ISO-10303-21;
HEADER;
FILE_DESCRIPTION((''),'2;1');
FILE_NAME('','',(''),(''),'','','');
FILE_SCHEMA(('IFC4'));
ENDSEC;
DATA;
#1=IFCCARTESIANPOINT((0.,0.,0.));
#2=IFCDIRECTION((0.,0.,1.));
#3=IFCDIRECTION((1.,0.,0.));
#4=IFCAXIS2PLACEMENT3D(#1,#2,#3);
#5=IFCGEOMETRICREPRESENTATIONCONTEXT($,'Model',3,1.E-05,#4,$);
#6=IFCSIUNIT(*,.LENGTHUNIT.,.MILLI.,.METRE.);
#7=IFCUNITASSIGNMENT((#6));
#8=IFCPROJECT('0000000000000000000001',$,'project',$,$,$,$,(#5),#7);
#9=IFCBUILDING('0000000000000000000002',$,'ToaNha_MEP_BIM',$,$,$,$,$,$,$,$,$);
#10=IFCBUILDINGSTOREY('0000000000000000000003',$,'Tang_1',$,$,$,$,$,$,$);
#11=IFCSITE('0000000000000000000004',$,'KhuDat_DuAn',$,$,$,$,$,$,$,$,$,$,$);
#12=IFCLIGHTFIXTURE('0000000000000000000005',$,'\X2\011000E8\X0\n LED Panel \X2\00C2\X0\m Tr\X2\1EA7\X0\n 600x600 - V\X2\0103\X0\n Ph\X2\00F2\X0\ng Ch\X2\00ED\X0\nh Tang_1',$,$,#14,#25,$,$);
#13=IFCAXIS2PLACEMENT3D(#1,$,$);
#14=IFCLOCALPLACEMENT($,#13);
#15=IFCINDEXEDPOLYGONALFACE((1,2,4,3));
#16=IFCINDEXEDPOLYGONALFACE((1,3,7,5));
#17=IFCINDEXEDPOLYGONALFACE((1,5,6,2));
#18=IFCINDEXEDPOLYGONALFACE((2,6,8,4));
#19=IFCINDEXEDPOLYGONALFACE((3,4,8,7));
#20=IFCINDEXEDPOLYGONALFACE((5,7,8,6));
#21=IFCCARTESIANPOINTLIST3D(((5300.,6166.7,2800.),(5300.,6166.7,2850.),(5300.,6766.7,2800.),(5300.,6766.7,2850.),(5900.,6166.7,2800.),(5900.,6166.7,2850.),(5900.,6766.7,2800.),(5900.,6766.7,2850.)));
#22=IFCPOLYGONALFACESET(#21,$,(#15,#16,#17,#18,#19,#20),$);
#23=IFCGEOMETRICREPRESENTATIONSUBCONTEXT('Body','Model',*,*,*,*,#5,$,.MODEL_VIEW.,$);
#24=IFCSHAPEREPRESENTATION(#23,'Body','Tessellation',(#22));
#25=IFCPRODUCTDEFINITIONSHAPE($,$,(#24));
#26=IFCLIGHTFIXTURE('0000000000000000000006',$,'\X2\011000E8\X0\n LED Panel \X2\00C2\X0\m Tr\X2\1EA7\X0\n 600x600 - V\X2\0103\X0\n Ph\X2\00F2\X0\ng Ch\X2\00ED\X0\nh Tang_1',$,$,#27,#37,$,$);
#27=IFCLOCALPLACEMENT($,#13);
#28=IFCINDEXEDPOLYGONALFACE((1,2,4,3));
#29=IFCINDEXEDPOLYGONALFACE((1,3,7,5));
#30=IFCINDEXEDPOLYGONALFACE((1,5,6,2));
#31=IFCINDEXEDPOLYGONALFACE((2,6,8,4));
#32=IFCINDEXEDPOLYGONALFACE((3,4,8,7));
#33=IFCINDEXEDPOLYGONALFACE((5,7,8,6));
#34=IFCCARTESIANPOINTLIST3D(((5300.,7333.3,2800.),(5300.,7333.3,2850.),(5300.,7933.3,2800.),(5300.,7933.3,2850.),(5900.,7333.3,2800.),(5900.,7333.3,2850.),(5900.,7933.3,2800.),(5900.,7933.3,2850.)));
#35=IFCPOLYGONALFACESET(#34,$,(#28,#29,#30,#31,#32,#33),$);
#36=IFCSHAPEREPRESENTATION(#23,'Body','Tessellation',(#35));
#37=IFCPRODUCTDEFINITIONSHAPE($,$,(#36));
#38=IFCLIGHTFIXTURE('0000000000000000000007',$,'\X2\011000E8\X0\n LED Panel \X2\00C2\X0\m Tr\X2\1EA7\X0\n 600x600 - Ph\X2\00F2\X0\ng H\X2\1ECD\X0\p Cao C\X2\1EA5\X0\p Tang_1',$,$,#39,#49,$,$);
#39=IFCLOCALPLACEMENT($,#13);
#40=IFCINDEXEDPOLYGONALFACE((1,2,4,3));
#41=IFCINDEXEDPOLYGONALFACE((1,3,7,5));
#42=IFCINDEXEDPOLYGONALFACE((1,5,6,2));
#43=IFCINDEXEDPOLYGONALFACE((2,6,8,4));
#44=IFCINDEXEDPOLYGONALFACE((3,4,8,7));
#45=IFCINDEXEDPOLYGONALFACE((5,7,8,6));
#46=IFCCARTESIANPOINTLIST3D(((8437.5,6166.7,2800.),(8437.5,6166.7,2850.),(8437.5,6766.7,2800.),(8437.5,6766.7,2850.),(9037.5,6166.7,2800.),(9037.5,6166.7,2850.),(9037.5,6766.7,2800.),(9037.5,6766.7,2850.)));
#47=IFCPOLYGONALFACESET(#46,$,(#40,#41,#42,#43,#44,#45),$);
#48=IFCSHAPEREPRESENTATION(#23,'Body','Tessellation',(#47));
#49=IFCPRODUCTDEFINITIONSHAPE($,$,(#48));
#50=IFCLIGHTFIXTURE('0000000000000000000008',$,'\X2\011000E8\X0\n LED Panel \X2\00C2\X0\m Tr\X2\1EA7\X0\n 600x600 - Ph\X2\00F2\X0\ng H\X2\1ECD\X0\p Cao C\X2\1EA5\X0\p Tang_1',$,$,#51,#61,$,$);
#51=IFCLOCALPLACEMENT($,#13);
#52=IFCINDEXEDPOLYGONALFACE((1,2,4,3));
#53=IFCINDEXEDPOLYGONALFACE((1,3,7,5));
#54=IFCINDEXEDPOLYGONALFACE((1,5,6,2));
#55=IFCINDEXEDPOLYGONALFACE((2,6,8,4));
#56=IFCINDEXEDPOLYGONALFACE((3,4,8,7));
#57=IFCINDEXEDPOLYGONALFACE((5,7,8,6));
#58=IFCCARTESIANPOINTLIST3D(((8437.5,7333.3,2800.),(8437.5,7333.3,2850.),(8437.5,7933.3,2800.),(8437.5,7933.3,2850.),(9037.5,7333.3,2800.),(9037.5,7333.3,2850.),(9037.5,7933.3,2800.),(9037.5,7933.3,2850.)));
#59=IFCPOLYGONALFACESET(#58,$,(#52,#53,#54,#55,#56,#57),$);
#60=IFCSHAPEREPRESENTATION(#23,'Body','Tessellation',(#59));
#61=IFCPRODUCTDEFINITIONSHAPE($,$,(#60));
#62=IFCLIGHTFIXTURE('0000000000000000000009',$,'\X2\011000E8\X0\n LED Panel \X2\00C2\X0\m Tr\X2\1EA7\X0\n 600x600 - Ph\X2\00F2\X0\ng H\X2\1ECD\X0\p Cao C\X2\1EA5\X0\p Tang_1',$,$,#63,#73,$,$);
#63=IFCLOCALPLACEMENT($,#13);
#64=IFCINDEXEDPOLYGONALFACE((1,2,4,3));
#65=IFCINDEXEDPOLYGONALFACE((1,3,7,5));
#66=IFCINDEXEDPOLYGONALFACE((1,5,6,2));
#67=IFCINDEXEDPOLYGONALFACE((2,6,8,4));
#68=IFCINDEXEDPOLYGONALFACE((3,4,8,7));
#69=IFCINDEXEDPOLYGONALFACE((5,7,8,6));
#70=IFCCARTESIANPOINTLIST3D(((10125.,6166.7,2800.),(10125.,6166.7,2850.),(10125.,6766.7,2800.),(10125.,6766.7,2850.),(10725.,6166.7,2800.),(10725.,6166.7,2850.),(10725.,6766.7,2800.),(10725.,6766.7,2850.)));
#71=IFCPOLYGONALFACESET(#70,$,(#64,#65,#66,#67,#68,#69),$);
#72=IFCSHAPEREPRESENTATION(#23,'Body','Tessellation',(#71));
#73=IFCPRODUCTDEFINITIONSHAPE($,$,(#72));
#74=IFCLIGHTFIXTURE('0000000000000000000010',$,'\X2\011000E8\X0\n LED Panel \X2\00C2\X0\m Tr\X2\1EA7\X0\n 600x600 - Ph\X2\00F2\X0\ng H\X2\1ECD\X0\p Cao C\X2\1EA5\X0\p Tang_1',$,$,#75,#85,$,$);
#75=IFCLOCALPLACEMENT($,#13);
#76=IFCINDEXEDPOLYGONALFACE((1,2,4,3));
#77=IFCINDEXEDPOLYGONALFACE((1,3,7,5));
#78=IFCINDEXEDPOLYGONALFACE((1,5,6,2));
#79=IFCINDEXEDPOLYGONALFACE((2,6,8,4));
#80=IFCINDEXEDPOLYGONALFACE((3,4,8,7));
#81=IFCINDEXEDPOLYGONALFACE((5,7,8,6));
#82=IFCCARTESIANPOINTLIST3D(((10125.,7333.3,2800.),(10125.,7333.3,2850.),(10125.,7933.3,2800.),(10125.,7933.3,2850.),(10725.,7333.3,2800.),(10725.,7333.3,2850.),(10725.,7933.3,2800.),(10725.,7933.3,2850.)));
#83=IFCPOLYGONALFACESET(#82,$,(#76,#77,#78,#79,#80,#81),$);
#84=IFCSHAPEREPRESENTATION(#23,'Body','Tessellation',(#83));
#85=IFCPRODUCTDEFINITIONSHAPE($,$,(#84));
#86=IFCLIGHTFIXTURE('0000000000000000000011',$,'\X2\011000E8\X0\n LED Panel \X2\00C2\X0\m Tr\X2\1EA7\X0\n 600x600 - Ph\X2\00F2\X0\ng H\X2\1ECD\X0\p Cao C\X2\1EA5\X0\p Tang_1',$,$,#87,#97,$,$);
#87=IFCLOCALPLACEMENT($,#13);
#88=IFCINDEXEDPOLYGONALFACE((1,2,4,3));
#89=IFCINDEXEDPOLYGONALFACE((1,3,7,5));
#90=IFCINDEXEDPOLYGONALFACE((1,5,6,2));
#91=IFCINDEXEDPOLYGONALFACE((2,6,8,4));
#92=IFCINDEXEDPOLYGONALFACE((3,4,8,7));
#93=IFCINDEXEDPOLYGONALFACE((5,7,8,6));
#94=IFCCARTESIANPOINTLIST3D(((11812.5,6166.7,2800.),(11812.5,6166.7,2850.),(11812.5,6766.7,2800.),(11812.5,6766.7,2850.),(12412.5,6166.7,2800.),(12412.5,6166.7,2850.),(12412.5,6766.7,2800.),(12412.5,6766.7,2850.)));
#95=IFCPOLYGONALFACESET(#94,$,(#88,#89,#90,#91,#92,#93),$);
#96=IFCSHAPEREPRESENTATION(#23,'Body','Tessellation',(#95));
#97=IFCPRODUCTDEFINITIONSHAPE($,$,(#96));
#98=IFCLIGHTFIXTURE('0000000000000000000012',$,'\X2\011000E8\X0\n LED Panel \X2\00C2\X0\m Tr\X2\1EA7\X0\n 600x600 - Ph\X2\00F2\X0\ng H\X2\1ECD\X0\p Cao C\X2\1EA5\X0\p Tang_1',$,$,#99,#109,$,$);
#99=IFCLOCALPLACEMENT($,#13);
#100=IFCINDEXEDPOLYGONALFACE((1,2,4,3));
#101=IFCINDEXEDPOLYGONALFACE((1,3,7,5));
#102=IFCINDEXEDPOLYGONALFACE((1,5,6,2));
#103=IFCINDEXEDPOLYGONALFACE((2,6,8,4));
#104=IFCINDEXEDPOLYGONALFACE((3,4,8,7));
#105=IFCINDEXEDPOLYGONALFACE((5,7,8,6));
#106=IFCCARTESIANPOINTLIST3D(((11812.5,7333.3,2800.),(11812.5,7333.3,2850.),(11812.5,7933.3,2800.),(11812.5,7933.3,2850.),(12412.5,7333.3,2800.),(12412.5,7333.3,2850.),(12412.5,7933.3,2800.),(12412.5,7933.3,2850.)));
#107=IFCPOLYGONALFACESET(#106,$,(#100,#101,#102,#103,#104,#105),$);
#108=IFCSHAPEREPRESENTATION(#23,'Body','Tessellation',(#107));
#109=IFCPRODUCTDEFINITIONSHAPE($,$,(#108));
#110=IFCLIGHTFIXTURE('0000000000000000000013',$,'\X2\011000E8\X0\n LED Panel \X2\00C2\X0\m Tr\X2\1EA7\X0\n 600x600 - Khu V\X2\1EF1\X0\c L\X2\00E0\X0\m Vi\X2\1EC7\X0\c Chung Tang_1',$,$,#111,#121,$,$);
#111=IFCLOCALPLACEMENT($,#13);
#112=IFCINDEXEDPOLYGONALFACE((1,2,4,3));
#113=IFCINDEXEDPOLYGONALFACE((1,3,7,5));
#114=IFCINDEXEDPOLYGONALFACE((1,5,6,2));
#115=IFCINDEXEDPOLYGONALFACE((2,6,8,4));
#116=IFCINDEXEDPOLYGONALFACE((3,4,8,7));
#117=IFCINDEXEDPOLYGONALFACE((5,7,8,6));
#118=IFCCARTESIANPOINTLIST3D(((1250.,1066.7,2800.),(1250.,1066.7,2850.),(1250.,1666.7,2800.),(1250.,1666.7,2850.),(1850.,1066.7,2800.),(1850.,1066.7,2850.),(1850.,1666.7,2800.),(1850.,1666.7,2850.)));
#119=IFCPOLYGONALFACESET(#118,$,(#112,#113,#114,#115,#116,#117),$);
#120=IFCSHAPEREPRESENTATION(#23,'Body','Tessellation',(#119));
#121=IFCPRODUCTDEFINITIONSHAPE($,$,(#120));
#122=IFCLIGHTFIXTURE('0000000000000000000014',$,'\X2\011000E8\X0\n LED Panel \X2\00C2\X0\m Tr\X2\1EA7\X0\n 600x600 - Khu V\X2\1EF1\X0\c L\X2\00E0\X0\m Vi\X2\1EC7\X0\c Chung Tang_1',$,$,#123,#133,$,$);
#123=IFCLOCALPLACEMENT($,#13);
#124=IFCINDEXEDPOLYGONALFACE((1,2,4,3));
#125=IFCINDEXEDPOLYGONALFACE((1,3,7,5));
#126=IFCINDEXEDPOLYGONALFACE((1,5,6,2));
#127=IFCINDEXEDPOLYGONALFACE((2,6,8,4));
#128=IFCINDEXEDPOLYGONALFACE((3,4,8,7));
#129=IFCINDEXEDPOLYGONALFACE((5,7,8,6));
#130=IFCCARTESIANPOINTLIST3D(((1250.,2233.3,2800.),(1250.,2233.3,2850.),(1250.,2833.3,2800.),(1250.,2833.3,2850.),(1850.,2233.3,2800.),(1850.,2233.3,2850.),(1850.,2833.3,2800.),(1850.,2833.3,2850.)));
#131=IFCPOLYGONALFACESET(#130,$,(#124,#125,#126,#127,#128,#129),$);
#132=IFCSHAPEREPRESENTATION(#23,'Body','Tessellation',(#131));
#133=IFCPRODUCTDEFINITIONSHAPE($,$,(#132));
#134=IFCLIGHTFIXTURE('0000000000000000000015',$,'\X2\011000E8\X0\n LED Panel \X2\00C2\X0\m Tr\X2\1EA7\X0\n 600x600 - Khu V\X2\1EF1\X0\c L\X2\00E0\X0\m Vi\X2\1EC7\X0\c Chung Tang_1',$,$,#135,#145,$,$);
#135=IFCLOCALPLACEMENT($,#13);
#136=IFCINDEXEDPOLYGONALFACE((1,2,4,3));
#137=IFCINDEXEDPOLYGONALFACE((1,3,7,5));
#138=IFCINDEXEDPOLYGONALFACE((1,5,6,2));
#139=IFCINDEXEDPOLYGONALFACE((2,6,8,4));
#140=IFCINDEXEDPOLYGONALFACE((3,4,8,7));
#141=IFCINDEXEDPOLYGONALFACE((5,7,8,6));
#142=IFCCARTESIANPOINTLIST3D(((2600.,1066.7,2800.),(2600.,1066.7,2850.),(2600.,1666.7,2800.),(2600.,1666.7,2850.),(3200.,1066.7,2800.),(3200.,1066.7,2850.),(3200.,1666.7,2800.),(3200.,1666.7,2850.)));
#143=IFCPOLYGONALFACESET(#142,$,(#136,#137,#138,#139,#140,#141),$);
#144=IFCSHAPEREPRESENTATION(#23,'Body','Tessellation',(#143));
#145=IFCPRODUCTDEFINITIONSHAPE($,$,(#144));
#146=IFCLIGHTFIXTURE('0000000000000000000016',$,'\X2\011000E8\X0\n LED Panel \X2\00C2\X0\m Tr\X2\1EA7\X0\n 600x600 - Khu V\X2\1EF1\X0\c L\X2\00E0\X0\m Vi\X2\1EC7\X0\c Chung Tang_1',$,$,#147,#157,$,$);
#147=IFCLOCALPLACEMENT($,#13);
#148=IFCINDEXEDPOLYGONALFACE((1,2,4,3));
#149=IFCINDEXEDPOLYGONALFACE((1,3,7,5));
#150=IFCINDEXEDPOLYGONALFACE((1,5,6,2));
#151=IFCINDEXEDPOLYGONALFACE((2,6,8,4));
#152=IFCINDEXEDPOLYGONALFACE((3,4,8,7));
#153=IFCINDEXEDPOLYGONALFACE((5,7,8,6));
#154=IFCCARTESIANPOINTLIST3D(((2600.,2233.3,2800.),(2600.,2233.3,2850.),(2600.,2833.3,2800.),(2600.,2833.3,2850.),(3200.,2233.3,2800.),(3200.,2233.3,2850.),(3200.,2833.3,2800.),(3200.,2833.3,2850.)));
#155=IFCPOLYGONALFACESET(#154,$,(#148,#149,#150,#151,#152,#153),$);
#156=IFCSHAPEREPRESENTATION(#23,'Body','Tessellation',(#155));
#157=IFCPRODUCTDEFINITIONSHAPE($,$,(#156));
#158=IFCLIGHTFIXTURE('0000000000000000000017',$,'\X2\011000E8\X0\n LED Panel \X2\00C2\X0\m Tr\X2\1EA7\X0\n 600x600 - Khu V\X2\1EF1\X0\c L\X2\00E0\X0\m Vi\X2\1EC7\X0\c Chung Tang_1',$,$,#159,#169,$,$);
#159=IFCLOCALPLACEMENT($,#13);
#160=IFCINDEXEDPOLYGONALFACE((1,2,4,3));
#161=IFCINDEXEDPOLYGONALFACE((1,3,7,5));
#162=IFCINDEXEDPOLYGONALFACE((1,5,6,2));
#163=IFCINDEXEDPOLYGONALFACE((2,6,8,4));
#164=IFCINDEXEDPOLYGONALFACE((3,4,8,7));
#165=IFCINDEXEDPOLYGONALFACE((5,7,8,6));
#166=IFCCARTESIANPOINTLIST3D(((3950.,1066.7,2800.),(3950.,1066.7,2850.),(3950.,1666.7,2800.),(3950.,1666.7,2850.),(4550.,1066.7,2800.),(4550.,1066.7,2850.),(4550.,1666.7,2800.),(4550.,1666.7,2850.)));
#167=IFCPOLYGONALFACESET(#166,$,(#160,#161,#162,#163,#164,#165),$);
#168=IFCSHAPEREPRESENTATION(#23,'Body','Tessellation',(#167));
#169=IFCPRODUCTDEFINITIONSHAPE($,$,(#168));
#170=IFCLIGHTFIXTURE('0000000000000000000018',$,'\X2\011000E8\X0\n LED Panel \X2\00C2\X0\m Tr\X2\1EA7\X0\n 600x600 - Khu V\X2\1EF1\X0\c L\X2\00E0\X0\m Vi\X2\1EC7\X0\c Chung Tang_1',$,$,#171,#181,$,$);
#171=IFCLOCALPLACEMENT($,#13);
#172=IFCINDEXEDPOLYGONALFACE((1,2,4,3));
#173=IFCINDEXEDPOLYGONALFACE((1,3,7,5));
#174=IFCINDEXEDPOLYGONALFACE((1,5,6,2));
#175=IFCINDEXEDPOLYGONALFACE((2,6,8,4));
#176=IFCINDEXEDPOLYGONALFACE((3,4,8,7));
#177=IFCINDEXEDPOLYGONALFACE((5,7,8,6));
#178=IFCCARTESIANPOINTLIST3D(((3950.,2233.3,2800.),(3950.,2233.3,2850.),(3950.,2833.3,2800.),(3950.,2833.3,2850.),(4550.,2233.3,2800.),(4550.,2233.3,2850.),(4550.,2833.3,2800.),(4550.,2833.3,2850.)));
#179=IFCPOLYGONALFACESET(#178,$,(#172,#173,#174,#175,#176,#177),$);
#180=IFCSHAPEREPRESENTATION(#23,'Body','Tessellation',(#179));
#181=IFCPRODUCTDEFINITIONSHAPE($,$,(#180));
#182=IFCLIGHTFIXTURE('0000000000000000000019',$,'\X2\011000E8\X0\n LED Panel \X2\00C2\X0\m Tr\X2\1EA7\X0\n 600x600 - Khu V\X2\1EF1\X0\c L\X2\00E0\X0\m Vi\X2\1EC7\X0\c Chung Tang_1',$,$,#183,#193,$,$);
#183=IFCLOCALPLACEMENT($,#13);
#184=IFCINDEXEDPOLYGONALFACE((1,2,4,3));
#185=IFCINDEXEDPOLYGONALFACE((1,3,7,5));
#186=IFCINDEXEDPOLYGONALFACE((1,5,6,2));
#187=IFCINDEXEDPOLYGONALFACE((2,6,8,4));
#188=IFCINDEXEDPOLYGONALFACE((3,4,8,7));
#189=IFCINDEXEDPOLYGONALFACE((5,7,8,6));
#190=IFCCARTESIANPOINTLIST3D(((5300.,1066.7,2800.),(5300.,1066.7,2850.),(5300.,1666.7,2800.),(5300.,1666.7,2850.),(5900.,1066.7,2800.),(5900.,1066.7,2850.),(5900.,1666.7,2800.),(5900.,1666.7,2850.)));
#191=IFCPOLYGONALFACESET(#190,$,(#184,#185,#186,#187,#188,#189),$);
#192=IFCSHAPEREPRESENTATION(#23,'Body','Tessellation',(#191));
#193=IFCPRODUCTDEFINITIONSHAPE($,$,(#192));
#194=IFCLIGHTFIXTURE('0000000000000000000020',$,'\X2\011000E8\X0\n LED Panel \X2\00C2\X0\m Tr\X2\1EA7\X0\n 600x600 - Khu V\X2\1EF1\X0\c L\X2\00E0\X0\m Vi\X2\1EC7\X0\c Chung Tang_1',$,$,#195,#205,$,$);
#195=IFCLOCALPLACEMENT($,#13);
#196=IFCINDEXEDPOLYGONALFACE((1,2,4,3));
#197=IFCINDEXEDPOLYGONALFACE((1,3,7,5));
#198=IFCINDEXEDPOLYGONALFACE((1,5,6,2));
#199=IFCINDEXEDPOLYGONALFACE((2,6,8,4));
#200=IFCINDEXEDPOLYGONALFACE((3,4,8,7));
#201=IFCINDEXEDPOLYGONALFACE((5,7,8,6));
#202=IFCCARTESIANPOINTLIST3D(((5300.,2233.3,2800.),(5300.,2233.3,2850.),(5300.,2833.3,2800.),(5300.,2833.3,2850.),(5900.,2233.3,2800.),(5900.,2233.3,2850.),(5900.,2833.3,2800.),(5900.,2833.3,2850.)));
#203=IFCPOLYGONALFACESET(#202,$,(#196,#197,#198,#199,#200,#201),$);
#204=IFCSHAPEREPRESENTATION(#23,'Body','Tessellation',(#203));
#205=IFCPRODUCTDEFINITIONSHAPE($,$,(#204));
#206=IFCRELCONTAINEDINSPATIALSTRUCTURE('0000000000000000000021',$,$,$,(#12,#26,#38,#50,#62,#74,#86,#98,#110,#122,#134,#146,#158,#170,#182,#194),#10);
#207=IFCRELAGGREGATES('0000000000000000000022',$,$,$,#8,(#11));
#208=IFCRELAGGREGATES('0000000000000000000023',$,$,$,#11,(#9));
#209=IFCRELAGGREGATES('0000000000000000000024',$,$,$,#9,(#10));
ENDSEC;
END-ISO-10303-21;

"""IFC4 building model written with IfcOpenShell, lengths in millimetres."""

from ifc_helpers import new_model, si_unit, frame, origin_with_axes, context, subcontext, project, spatial, polyline, outline, extrude, element, save


model = new_model("IFC4")

# Units and contexts
model_context = context("Model", 3, precision=1e-05, world=origin_with_axes())
body_context = subcontext(model_context, "Body", "Model", "MODEL_VIEW")
ifc_project = project(units=[si_unit("LENGTHUNIT", "METRE", prefix="MILLI")], contexts=[model_context])

# Site, building, storey
site = spatial("IfcSite", under=ifc_project, Name="KhuDat_DuAn")
building = spatial("IfcBuilding", under=site, Name="ToaNha_MEP_BIM")
storey = spatial("IfcBuildingStorey", under=building, Name="Tang_1")

# Light fixtures
element("IfcLightFixture", 1, inside=storey, Name="Đèn LED Panel Âm Trần 600x600 - Văn Phòng Chính Tang_1", context=body_context, shape_type="SweptSolid", body=[
    extrude(outline(polyline([(5300.0, 6166.7), (5900.0, 6166.7), (5900.0, 6766.7), (5300.0, 6766.7), (5300.0, 6166.7)])), frame((0.0, 0.0, 2800.0), z_axis=(0.0, 0.0, 1.0), x_axis=(1.0, 0.0, 0.0)), (0.0, 0.0, 1.0), 50.0),
])
element("IfcLightFixture", 2, inside=storey, Name="Đèn LED Panel Âm Trần 600x600 - Văn Phòng Chính Tang_1", context=body_context, shape_type="SweptSolid", body=[
    extrude(outline(polyline([(5300.0, 7333.3), (5900.0, 7333.3), (5900.0, 7933.3), (5300.0, 7933.3), (5300.0, 7333.3)])), frame((0.0, 0.0, 2800.0), z_axis=(0.0, 0.0, 1.0), x_axis=(1.0, 0.0, 0.0)), (0.0, 0.0, 1.0), 50.0),
])
element("IfcLightFixture", 3, inside=storey, Name="Đèn LED Panel Âm Trần 600x600 - Phòng Họp Cao Cấp Tang_1", context=body_context, shape_type="SweptSolid", body=[
    extrude(outline(polyline([(8437.5, 6166.7), (9037.5, 6166.7), (9037.5, 6766.7), (8437.5, 6766.7), (8437.5, 6166.7)])), frame((0.0, 0.0, 2800.0), z_axis=(0.0, 0.0, 1.0), x_axis=(1.0, 0.0, 0.0)), (0.0, 0.0, 1.0), 50.0),
])
element("IfcLightFixture", 4, inside=storey, Name="Đèn LED Panel Âm Trần 600x600 - Phòng Họp Cao Cấp Tang_1", context=body_context, shape_type="SweptSolid", body=[
    extrude(outline(polyline([(8437.5, 7333.3), (9037.5, 7333.3), (9037.5, 7933.3), (8437.5, 7933.3), (8437.5, 7333.3)])), frame((0.0, 0.0, 2800.0), z_axis=(0.0, 0.0, 1.0), x_axis=(1.0, 0.0, 0.0)), (0.0, 0.0, 1.0), 50.0),
])
element("IfcLightFixture", 5, inside=storey, Name="Đèn LED Panel Âm Trần 600x600 - Phòng Họp Cao Cấp Tang_1", context=body_context, shape_type="SweptSolid", body=[
    extrude(outline(polyline([(10125.0, 6166.7), (10725.0, 6166.7), (10725.0, 6766.7), (10125.0, 6766.7), (10125.0, 6166.7)])), frame((0.0, 0.0, 2800.0), z_axis=(0.0, 0.0, 1.0), x_axis=(1.0, 0.0, 0.0)), (0.0, 0.0, 1.0), 50.0),
])
element("IfcLightFixture", 6, inside=storey, Name="Đèn LED Panel Âm Trần 600x600 - Phòng Họp Cao Cấp Tang_1", context=body_context, shape_type="SweptSolid", body=[
    extrude(outline(polyline([(10125.0, 7333.3), (10725.0, 7333.3), (10725.0, 7933.3), (10125.0, 7933.3), (10125.0, 7333.3)])), frame((0.0, 0.0, 2800.0), z_axis=(0.0, 0.0, 1.0), x_axis=(1.0, 0.0, 0.0)), (0.0, 0.0, 1.0), 50.0),
])
element("IfcLightFixture", 7, inside=storey, Name="Đèn LED Panel Âm Trần 600x600 - Phòng Họp Cao Cấp Tang_1", context=body_context, shape_type="SweptSolid", body=[
    extrude(outline(polyline([(11812.5, 6166.7), (12412.5, 6166.7), (12412.5, 6766.7), (11812.5, 6766.7), (11812.5, 6166.7)])), frame((0.0, 0.0, 2800.0), z_axis=(0.0, 0.0, 1.0), x_axis=(1.0, 0.0, 0.0)), (0.0, 0.0, 1.0), 50.0),
])
element("IfcLightFixture", 8, inside=storey, Name="Đèn LED Panel Âm Trần 600x600 - Phòng Họp Cao Cấp Tang_1", context=body_context, shape_type="SweptSolid", body=[
    extrude(outline(polyline([(11812.5, 7333.3), (12412.5, 7333.3), (12412.5, 7933.3), (11812.5, 7933.3), (11812.5, 7333.3)])), frame((0.0, 0.0, 2800.0), z_axis=(0.0, 0.0, 1.0), x_axis=(1.0, 0.0, 0.0)), (0.0, 0.0, 1.0), 50.0),
])
element("IfcLightFixture", 9, inside=storey, Name="Đèn LED Panel Âm Trần 600x600 - Khu Vực Làm Việc Chung Tang_1", context=body_context, shape_type="SweptSolid", body=[
    extrude(outline(polyline([(1250.0, 1066.7), (1850.0, 1066.7), (1850.0, 1666.7), (1250.0, 1666.7), (1250.0, 1066.7)])), frame((0.0, 0.0, 2800.0), z_axis=(0.0, 0.0, 1.0), x_axis=(1.0, 0.0, 0.0)), (0.0, 0.0, 1.0), 50.0),
])
element("IfcLightFixture", 10, inside=storey, Name="Đèn LED Panel Âm Trần 600x600 - Khu Vực Làm Việc Chung Tang_1", context=body_context, shape_type="SweptSolid", body=[
    extrude(outline(polyline([(1250.0, 2233.3), (1850.0, 2233.3), (1850.0, 2833.3), (1250.0, 2833.3), (1250.0, 2233.3)])), frame((0.0, 0.0, 2800.0), z_axis=(0.0, 0.0, 1.0), x_axis=(1.0, 0.0, 0.0)), (0.0, 0.0, 1.0), 50.0),
])
element("IfcLightFixture", 11, inside=storey, Name="Đèn LED Panel Âm Trần 600x600 - Khu Vực Làm Việc Chung Tang_1", context=body_context, shape_type="SweptSolid", body=[
    extrude(outline(polyline([(2600.0, 1066.7), (3200.0, 1066.7), (3200.0, 1666.7), (2600.0, 1666.7), (2600.0, 1066.7)])), frame((0.0, 0.0, 2800.0), z_axis=(0.0, 0.0, 1.0), x_axis=(1.0, 0.0, 0.0)), (0.0, 0.0, 1.0), 50.0),
])
element("IfcLightFixture", 12, inside=storey, Name="Đèn LED Panel Âm Trần 600x600 - Khu Vực Làm Việc Chung Tang_1", context=body_context, shape_type="SweptSolid", body=[
    extrude(outline(polyline([(2600.0, 2233.3), (3200.0, 2233.3), (3200.0, 2833.3), (2600.0, 2833.3), (2600.0, 2233.3)])), frame((0.0, 0.0, 2800.0), z_axis=(0.0, 0.0, 1.0), x_axis=(1.0, 0.0, 0.0)), (0.0, 0.0, 1.0), 50.0),
])
element("IfcLightFixture", 13, inside=storey, Name="Đèn LED Panel Âm Trần 600x600 - Khu Vực Làm Việc Chung Tang_1", context=body_context, shape_type="SweptSolid", body=[
    extrude(outline(polyline([(3950.0, 1066.7), (4550.0, 1066.7), (4550.0, 1666.7), (3950.0, 1666.7), (3950.0, 1066.7)])), frame((0.0, 0.0, 2800.0), z_axis=(0.0, 0.0, 1.0), x_axis=(1.0, 0.0, 0.0)), (0.0, 0.0, 1.0), 50.0),
])
element("IfcLightFixture", 14, inside=storey, Name="Đèn LED Panel Âm Trần 600x600 - Khu Vực Làm Việc Chung Tang_1", context=body_context, shape_type="SweptSolid", body=[
    extrude(outline(polyline([(3950.0, 2233.3), (4550.0, 2233.3), (4550.0, 2833.3), (3950.0, 2833.3), (3950.0, 2233.3)])), frame((0.0, 0.0, 2800.0), z_axis=(0.0, 0.0, 1.0), x_axis=(1.0, 0.0, 0.0)), (0.0, 0.0, 1.0), 50.0),
])
element("IfcLightFixture", 15, inside=storey, Name="Đèn LED Panel Âm Trần 600x600 - Khu Vực Làm Việc Chung Tang_1", context=body_context, shape_type="SweptSolid", body=[
    extrude(outline(polyline([(5300.0, 1066.7), (5900.0, 1066.7), (5900.0, 1666.7), (5300.0, 1666.7), (5300.0, 1066.7)])), frame((0.0, 0.0, 2800.0), z_axis=(0.0, 0.0, 1.0), x_axis=(1.0, 0.0, 0.0)), (0.0, 0.0, 1.0), 50.0),
])
element("IfcLightFixture", 16, inside=storey, Name="Đèn LED Panel Âm Trần 600x600 - Khu Vực Làm Việc Chung Tang_1", context=body_context, shape_type="SweptSolid", body=[
    extrude(outline(polyline([(5300.0, 2233.3), (5900.0, 2233.3), (5900.0, 2833.3), (5300.0, 2833.3), (5300.0, 2233.3)])), frame((0.0, 0.0, 2800.0), z_axis=(0.0, 0.0, 1.0), x_axis=(1.0, 0.0, 0.0)), (0.0, 0.0, 1.0), 50.0),
])

save(model, "model.ifc")
